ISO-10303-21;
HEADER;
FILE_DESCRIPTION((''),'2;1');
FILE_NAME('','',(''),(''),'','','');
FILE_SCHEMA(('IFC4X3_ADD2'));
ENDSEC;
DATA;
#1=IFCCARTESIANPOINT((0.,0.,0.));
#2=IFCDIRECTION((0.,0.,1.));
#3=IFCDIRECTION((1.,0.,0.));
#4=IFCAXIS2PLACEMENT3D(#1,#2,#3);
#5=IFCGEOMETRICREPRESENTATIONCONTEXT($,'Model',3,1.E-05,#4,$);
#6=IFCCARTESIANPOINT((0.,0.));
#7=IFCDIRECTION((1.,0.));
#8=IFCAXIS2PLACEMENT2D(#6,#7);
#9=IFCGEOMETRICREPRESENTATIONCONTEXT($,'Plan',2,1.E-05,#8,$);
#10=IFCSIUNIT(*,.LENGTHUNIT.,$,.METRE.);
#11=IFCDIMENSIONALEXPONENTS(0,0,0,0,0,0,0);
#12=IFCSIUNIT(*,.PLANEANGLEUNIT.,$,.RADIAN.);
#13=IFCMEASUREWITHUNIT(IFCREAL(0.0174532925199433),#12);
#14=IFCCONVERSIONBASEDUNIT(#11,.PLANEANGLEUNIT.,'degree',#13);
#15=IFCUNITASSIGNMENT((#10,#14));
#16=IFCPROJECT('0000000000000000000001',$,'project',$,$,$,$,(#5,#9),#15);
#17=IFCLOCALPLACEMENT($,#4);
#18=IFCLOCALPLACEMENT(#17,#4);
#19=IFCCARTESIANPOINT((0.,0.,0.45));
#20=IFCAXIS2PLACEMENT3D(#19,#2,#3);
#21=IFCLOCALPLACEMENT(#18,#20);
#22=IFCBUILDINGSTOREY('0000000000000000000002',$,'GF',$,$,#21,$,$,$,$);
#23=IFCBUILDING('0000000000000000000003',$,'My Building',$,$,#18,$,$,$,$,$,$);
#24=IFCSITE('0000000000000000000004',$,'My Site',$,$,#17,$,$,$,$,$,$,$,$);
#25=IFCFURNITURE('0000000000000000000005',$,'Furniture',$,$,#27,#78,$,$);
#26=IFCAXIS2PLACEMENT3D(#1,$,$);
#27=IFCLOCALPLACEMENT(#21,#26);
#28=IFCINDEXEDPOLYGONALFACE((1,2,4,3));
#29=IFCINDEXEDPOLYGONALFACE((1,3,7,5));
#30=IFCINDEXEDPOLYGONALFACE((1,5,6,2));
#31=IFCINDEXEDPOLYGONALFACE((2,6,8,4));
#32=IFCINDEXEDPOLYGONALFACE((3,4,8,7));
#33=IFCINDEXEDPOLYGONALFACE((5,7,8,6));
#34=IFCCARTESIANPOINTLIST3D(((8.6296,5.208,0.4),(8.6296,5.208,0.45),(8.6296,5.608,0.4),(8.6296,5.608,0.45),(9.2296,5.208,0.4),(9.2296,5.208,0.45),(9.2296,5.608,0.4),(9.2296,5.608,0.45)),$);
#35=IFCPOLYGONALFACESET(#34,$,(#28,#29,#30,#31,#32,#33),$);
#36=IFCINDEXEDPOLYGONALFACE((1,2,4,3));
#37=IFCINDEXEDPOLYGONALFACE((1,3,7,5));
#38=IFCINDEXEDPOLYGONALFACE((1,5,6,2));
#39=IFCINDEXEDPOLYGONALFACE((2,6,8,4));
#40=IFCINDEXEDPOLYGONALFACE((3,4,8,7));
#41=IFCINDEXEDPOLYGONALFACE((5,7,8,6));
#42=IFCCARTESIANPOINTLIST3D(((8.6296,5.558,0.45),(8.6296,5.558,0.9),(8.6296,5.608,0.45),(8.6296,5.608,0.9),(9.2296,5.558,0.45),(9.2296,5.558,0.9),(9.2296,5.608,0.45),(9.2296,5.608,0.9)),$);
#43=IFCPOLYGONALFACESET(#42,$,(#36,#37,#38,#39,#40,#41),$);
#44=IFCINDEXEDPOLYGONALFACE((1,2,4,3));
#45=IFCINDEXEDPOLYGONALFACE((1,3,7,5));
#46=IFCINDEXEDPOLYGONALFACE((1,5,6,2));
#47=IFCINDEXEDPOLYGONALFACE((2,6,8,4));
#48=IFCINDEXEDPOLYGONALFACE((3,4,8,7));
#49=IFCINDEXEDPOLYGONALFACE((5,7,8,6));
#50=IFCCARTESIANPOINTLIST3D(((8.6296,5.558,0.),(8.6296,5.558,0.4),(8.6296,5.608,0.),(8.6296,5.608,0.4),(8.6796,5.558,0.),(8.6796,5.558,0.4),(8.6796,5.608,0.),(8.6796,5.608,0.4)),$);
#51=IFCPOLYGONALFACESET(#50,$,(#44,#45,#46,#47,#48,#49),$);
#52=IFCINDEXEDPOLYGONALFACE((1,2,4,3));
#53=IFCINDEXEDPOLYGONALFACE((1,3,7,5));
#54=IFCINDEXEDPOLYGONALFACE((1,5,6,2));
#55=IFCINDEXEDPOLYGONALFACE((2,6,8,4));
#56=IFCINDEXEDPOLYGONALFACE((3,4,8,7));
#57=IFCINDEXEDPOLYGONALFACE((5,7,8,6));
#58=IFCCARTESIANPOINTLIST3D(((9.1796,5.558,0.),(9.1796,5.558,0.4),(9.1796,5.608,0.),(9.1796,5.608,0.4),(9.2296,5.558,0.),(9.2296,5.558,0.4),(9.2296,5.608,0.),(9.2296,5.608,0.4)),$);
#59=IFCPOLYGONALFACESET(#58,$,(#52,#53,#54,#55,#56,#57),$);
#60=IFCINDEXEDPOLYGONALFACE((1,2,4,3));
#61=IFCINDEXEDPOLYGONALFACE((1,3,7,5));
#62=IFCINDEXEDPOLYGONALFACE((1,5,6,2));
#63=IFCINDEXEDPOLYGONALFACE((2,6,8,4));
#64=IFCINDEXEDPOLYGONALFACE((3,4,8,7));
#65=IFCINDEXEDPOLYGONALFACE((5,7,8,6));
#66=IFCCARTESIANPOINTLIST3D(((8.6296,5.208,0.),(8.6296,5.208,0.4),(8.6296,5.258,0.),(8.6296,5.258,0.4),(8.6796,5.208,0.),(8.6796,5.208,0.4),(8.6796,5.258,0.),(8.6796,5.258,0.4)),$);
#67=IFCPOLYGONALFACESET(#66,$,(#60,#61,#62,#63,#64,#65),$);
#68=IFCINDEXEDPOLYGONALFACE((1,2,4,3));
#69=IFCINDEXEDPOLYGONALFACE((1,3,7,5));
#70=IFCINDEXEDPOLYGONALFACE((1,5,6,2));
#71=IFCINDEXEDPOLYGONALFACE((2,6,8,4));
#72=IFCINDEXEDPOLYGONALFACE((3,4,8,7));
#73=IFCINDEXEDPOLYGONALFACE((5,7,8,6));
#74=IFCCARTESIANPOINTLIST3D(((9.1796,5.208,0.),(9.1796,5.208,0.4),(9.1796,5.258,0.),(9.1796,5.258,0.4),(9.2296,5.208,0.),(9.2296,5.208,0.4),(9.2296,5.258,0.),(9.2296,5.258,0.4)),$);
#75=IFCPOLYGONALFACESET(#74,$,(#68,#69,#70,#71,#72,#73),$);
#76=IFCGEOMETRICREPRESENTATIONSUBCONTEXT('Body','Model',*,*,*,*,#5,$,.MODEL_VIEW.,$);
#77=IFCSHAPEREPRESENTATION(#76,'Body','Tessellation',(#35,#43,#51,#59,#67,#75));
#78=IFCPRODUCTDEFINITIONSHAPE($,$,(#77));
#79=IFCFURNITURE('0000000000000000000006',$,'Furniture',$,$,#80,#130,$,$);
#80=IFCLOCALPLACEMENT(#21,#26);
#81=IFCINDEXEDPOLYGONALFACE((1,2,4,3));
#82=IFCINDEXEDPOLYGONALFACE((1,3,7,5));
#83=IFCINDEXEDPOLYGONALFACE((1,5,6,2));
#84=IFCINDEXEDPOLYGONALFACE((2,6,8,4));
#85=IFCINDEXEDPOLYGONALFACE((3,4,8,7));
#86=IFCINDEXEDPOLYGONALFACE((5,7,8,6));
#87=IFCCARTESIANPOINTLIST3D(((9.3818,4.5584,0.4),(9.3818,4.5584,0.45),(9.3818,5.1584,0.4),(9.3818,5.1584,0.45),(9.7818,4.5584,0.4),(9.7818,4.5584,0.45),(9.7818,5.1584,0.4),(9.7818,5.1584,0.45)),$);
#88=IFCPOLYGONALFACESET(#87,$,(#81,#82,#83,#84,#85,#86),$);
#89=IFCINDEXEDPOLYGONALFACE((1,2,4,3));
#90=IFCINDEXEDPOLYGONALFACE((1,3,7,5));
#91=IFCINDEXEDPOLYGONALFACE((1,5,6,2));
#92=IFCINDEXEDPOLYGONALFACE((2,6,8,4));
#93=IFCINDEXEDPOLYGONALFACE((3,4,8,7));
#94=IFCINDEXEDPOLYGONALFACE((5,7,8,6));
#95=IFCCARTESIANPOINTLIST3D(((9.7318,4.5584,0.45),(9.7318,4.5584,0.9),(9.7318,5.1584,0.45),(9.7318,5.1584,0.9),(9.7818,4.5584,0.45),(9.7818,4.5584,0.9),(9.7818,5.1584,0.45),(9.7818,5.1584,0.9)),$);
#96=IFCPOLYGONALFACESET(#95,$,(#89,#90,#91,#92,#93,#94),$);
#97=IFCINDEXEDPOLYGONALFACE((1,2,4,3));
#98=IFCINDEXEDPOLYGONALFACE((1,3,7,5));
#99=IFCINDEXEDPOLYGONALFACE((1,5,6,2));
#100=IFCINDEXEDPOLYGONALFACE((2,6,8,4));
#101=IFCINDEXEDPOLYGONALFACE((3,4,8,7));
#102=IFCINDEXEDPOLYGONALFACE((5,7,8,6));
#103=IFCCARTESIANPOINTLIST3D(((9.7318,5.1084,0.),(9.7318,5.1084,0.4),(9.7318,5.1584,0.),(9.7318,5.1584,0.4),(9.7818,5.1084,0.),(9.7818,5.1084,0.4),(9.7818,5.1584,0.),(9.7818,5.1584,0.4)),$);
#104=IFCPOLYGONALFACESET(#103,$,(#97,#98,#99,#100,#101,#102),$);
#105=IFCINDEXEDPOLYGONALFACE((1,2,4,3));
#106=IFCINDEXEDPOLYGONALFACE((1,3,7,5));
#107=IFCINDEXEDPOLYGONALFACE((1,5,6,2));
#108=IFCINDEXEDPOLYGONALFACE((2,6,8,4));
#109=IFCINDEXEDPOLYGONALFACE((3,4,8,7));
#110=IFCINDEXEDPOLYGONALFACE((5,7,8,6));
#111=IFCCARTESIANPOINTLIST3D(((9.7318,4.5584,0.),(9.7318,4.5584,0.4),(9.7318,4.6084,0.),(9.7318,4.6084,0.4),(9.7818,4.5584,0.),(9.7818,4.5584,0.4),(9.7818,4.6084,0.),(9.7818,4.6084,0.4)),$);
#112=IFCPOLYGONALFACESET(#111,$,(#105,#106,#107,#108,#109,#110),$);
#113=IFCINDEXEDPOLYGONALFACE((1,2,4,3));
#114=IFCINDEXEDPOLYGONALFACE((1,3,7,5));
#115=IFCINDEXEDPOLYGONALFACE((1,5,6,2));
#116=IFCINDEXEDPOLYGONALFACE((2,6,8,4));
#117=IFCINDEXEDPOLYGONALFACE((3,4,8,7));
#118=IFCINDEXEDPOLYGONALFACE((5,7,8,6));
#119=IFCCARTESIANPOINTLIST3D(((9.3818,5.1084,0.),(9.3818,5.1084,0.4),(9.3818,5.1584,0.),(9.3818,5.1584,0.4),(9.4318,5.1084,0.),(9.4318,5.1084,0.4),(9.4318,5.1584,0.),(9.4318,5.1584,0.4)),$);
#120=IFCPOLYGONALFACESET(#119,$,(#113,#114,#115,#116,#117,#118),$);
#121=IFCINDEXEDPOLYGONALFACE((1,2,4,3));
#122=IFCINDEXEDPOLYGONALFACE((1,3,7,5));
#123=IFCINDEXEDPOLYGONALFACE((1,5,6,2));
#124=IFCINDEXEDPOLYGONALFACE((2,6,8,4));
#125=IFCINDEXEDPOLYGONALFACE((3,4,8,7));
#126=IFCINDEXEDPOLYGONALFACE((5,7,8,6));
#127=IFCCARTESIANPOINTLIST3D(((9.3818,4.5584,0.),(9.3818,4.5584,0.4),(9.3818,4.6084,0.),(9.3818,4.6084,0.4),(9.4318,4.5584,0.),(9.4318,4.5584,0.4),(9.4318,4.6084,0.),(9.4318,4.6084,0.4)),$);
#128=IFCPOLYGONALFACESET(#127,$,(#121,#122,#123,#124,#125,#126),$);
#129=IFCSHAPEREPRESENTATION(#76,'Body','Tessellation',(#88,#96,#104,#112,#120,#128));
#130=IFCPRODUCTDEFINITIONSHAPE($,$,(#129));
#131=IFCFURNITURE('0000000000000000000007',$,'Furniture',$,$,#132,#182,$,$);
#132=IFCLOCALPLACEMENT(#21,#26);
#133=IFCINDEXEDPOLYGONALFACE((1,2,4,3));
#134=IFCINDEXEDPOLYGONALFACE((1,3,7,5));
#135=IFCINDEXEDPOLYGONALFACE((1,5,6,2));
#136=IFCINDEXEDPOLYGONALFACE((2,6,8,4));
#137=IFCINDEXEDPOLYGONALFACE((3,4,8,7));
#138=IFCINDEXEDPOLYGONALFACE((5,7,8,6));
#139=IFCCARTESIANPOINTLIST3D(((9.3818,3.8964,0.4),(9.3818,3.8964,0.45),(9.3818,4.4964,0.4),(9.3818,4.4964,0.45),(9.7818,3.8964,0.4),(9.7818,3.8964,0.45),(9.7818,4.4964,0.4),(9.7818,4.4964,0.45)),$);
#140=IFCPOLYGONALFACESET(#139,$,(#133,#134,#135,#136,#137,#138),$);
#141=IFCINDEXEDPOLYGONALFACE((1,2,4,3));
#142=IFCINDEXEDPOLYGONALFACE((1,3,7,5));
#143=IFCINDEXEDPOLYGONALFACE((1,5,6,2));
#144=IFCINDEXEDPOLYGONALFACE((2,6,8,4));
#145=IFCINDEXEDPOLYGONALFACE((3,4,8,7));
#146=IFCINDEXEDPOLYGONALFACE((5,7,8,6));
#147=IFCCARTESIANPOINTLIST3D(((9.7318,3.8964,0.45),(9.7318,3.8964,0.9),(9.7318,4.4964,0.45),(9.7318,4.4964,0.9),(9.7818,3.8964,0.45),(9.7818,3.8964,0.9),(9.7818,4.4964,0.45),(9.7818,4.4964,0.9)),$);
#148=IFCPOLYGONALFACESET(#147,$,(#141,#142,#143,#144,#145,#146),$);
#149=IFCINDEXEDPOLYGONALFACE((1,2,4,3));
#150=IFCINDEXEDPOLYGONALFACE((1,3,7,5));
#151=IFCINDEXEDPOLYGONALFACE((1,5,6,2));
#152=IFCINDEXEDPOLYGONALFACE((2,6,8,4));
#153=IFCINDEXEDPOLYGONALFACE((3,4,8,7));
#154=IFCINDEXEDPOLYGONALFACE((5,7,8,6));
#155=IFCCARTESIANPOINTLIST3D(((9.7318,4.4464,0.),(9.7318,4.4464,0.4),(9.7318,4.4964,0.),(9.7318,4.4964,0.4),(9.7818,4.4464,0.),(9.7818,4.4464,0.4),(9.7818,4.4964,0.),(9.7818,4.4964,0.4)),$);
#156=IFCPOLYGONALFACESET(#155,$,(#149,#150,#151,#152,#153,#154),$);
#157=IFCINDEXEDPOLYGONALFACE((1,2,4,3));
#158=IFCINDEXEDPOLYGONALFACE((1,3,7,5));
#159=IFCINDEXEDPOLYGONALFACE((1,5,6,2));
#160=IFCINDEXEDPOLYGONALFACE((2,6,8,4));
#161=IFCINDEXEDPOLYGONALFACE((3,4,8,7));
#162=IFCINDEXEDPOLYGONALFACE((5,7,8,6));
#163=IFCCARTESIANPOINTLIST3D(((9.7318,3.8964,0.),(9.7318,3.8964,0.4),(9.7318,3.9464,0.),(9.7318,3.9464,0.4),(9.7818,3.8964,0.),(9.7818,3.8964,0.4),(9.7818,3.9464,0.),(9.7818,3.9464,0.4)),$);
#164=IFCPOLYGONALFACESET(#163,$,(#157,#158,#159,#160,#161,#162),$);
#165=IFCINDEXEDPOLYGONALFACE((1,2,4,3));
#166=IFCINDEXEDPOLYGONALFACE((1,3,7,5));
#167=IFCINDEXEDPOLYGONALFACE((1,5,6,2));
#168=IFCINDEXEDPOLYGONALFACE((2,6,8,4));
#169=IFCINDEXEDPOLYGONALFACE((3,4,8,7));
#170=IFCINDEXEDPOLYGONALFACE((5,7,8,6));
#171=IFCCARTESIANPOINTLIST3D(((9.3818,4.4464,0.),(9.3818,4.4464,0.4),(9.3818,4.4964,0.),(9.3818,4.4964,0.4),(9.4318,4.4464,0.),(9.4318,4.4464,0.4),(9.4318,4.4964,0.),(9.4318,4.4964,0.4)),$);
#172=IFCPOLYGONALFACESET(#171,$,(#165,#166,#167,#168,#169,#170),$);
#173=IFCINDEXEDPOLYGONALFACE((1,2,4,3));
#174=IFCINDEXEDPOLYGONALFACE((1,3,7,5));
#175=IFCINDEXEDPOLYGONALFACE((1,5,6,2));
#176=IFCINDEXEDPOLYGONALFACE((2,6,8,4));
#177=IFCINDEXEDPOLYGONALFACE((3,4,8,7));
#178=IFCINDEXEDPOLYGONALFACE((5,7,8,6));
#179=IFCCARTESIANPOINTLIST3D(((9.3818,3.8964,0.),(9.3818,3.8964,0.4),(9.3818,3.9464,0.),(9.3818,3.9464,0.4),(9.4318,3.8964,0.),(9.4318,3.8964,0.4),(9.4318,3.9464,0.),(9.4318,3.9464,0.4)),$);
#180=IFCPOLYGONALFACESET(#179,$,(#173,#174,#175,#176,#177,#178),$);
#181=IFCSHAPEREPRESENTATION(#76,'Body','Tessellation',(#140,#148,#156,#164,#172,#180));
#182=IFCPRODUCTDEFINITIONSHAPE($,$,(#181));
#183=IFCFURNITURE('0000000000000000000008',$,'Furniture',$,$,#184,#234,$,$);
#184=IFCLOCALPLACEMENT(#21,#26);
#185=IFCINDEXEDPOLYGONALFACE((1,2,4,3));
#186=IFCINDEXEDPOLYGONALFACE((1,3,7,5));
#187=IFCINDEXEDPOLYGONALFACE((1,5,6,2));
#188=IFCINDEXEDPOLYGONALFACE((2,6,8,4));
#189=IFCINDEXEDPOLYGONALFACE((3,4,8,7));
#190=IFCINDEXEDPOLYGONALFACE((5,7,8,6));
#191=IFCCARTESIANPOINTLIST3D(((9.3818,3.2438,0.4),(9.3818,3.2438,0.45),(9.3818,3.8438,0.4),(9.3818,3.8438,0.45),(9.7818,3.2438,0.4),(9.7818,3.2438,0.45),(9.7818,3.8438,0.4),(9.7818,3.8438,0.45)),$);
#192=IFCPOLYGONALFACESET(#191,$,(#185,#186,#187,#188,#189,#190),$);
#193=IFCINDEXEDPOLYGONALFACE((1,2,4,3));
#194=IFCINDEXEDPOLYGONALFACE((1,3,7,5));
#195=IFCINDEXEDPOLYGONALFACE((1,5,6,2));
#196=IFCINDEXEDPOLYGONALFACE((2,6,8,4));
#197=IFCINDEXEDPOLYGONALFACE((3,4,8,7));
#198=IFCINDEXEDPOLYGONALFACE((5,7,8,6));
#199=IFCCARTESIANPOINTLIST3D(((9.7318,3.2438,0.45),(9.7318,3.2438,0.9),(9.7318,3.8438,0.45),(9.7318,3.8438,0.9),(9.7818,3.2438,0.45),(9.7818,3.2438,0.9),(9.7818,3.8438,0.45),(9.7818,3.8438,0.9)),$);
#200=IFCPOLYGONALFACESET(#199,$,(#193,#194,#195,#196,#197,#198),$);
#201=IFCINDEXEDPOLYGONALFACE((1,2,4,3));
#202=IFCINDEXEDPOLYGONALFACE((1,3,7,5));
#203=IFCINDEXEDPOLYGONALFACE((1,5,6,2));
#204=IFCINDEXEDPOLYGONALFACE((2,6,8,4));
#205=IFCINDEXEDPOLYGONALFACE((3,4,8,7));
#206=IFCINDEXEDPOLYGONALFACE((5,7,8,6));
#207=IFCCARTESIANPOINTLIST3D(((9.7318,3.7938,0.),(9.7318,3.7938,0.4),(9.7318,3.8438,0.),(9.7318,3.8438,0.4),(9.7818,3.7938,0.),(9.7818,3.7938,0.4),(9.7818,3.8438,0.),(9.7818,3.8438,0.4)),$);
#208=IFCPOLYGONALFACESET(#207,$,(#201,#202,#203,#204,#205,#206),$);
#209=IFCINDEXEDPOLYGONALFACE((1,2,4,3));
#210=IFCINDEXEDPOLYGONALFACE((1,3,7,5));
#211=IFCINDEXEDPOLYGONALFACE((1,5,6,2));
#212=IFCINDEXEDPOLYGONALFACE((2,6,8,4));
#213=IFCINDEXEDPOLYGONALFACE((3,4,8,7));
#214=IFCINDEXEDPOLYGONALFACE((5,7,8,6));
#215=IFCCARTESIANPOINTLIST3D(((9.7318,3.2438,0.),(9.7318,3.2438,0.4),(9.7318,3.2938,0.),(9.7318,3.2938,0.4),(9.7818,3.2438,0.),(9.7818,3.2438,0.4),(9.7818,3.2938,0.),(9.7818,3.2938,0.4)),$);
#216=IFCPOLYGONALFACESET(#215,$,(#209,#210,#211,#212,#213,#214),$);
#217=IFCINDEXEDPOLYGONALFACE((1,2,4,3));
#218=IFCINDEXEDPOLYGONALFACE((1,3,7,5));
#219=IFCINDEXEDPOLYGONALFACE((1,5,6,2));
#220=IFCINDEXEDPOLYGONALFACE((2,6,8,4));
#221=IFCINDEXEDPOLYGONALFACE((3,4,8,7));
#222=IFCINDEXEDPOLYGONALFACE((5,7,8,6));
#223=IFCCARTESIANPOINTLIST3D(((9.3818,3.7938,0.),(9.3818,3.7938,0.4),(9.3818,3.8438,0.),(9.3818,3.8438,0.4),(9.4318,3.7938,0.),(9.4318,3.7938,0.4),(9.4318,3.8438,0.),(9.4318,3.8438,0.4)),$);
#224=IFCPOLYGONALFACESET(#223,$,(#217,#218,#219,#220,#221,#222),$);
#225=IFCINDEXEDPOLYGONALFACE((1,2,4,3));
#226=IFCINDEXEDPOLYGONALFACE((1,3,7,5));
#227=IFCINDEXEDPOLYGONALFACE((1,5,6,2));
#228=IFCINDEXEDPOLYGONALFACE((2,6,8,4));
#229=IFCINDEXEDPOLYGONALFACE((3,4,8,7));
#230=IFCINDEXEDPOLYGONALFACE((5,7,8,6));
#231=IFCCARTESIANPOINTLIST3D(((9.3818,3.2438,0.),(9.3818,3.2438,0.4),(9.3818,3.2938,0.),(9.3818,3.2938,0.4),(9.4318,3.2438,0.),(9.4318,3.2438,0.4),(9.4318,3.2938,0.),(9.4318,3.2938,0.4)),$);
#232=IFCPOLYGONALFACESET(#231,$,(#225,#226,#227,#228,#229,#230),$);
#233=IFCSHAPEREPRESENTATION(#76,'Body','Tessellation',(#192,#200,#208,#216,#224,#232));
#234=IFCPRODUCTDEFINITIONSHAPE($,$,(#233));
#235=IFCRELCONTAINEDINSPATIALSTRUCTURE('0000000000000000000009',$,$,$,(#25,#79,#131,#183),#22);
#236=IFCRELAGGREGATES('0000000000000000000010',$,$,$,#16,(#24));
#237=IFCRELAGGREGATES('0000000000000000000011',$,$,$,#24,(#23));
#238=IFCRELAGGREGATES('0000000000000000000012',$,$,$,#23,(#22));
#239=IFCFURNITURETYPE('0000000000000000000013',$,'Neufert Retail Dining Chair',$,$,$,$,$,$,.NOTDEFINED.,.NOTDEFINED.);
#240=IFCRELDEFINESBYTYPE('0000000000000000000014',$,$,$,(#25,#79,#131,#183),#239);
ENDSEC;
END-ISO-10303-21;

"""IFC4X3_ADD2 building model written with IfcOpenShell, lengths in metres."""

from ifc_helpers import new_model, entity, si_unit, converted_unit, frame, origin_with_axes, origin_2d_with_axis, place, context, subcontext, project, spatial, line, indexed_curve, outline, extrude, shape, source, transform, mapped, type_object, type_shapes, element, save


model = new_model("IFC4X3_ADD2")

# Units and contexts
model_context = context("Model", 3, precision=1e-05, world=origin_with_axes())
plan_context = context("Plan", 2, precision=1e-05, world=origin_2d_with_axis())
body_context_1 = subcontext(model_context, "Body", "Model", "MODEL_VIEW")
body_context_2 = subcontext(plan_context, "Body", "Plan", "PLAN_VIEW")
ifc_project = project(units=[si_unit("LENGTHUNIT", "METRE"), converted_unit("PLANEANGLEUNIT", "degree", entity("IfcReal", 0.0174532925199433), si_unit("PLANEANGLEUNIT", "RADIAN"), dimensions=[0, 0, 0, 0, 0, 0, 0])], contexts=[model_context, plan_context])

# Site, building, storey
site_placement = place(None, origin_with_axes())
site = spatial("IfcSite", under=ifc_project, at=site_placement, Name="My Site")
building_placement = place(site_placement, origin_with_axes())
building = spatial("IfcBuilding", under=site, at=building_placement, Name="My Building")
storey_placement = place(building_placement, frame((0.0, 0.0, 0.45), z_axis=(0.0, 0.0, 1.0), x_axis=(1.0, 0.0, 0.0)))
storey = spatial("IfcBuildingStorey", under=building, at=storey_placement, Name="GF")

# Furniture
furniture_type_1 = type_object("IfcFurnitureType", Name="Neufert Retail Dining Chair", AssemblyPlace="NOTDEFINED", PredefinedType="NOTDEFINED")
shared_shape_1 = source(origin_with_axes(), body_context_1, "Body", "SweptSolid", [
    extrude(outline(indexed_curve([(-0.3, 0.0), (0.3, 0.0), (0.3, -0.4), (-0.3, -0.4)], segments=[line(1, 2, 3, 4, 1)])), frame((0.0, 0.0, 0.45), z_axis=(0.0, 0.0, 1.0), x_axis=(1.0, 0.0, 0.0)), (0.0, 0.0, -1.0), 0.05),
    extrude(outline(indexed_curve([(-0.3, 0.0), (0.3, 0.0), (0.3, -0.05), (-0.3, -0.05)], segments=[line(1, 2, 3, 4, 1)])), frame((0.0, 0.0, 0.9), z_axis=(0.0, 0.0, 1.0), x_axis=(1.0, 0.0, 0.0)), (0.0, 0.0, -1.0), 0.45),
    extrude(outline(indexed_curve([(-0.3, 0.0), (-0.25, 0.0), (-0.25, -0.05), (-0.3, -0.05)], segments=[line(1, 2, 3, 4, 1)])), origin_with_axes(), (0.0, 0.0, 1.0), 0.4),
    extrude(outline(indexed_curve([(0.3, 0.0), (0.25, 0.0), (0.25, -0.05), (0.3, -0.05)], segments=[line(1, 2, 3, 4, 1)])), origin_with_axes(), (0.0, 0.0, 1.0), 0.4),
    extrude(outline(indexed_curve([(-0.3, -0.4), (-0.25, -0.4), (-0.25, -0.35), (-0.3, -0.35)], segments=[line(1, 2, 3, 4, 1)])), origin_with_axes(), (0.0, 0.0, 1.0), 0.4),
    extrude(outline(indexed_curve([(0.3, -0.4), (0.25, -0.4), (0.25, -0.35), (0.3, -0.35)], segments=[line(1, 2, 3, 4, 1)])), origin_with_axes(), (0.0, 0.0, 1.0), 0.4),
])
shared_shape_2 = source(origin_with_axes(), body_context_2, "Body", "Curve2D", [
    entity("IfcIndexedPolyCurve", entity("IfcCartesianPointList2D", [[-0.3, -0.4], [0.3, -0.4]])),
    entity("IfcIndexedPolyCurve", entity("IfcCartesianPointList2D", [[-0.3, -0.4], [-0.3, -0.3], [-0.2121, -0.0879], [0.0, 0.0], [0.2121, -0.0879], [0.3, -0.3], [0.3, -0.4]]), [entity("IfcLineIndex", [1, 2]), entity("IfcArcIndex", [2, 3, 4]), entity("IfcArcIndex", [4, 5, 6]), entity("IfcLineIndex", [6, 7])]),
    entity("IfcIndexedPolyCurve", entity("IfcCartesianPointList2D", [[-0.26, -0.4], [-0.26, -0.3], [-0.1838, -0.1162], [0.0, -0.04], [0.1838, -0.1162], [0.26, -0.3], [0.26, -0.4]]), [entity("IfcLineIndex", [1, 2]), entity("IfcArcIndex", [2, 3, 4]), entity("IfcArcIndex", [4, 5, 6]), entity("IfcLineIndex", [6, 7])]),
])
type_shapes(furniture_type_1, [shared_shape_1, shared_shape_2])
for number, where, z_axis, x_axis, name in (
    (1, (8.9296, 5.608, 0.0), (0.0, 0.0, 1.0), (1.0, -0.000001, 0.0), "Furniture"),
    (2, (9.7818, 4.8584, 0.0), (0.0, 0.0, 1.0), (-0.000001, -1.0, 0.0), "Furniture"),
    (3, (9.7818, 4.1964, 0.0), (0.0, 0.0, 1.0), (-0.000001, -1.0, 0.0), "Furniture"),
    (4, (9.7818, 3.5438, 0.0), (0.0, 0.0, 1.0), (-0.000001, -1.0, 0.0), "Furniture"),
):
    element("IfcFurniture", number, at=place(storey_placement, frame(where, z_axis=z_axis, x_axis=x_axis)), inside=storey, type_object=furniture_type_1, Name=name, shapes=[
        shape(body_context_1, "Body", "MappedRepresentation", [mapped(shared_shape_1, transform((0.0, 0.0, 0.0), x_axis=(1.0, 0.0, 0.0), y_axis=(0.0, 1.0, 0.0), z_axis=(0.0, 0.0, 1.0), scale=1.0))]),
        shape(body_context_2, "Body", "MappedRepresentation", [mapped(shared_shape_2, transform((0.0, 0.0, 0.0), x_axis=(1.0, 0.0, 0.0), y_axis=(0.0, 1.0, 0.0), z_axis=(0.0, 0.0, 1.0), scale=1.0))]),
    ])

save(model, "model.ifc")
